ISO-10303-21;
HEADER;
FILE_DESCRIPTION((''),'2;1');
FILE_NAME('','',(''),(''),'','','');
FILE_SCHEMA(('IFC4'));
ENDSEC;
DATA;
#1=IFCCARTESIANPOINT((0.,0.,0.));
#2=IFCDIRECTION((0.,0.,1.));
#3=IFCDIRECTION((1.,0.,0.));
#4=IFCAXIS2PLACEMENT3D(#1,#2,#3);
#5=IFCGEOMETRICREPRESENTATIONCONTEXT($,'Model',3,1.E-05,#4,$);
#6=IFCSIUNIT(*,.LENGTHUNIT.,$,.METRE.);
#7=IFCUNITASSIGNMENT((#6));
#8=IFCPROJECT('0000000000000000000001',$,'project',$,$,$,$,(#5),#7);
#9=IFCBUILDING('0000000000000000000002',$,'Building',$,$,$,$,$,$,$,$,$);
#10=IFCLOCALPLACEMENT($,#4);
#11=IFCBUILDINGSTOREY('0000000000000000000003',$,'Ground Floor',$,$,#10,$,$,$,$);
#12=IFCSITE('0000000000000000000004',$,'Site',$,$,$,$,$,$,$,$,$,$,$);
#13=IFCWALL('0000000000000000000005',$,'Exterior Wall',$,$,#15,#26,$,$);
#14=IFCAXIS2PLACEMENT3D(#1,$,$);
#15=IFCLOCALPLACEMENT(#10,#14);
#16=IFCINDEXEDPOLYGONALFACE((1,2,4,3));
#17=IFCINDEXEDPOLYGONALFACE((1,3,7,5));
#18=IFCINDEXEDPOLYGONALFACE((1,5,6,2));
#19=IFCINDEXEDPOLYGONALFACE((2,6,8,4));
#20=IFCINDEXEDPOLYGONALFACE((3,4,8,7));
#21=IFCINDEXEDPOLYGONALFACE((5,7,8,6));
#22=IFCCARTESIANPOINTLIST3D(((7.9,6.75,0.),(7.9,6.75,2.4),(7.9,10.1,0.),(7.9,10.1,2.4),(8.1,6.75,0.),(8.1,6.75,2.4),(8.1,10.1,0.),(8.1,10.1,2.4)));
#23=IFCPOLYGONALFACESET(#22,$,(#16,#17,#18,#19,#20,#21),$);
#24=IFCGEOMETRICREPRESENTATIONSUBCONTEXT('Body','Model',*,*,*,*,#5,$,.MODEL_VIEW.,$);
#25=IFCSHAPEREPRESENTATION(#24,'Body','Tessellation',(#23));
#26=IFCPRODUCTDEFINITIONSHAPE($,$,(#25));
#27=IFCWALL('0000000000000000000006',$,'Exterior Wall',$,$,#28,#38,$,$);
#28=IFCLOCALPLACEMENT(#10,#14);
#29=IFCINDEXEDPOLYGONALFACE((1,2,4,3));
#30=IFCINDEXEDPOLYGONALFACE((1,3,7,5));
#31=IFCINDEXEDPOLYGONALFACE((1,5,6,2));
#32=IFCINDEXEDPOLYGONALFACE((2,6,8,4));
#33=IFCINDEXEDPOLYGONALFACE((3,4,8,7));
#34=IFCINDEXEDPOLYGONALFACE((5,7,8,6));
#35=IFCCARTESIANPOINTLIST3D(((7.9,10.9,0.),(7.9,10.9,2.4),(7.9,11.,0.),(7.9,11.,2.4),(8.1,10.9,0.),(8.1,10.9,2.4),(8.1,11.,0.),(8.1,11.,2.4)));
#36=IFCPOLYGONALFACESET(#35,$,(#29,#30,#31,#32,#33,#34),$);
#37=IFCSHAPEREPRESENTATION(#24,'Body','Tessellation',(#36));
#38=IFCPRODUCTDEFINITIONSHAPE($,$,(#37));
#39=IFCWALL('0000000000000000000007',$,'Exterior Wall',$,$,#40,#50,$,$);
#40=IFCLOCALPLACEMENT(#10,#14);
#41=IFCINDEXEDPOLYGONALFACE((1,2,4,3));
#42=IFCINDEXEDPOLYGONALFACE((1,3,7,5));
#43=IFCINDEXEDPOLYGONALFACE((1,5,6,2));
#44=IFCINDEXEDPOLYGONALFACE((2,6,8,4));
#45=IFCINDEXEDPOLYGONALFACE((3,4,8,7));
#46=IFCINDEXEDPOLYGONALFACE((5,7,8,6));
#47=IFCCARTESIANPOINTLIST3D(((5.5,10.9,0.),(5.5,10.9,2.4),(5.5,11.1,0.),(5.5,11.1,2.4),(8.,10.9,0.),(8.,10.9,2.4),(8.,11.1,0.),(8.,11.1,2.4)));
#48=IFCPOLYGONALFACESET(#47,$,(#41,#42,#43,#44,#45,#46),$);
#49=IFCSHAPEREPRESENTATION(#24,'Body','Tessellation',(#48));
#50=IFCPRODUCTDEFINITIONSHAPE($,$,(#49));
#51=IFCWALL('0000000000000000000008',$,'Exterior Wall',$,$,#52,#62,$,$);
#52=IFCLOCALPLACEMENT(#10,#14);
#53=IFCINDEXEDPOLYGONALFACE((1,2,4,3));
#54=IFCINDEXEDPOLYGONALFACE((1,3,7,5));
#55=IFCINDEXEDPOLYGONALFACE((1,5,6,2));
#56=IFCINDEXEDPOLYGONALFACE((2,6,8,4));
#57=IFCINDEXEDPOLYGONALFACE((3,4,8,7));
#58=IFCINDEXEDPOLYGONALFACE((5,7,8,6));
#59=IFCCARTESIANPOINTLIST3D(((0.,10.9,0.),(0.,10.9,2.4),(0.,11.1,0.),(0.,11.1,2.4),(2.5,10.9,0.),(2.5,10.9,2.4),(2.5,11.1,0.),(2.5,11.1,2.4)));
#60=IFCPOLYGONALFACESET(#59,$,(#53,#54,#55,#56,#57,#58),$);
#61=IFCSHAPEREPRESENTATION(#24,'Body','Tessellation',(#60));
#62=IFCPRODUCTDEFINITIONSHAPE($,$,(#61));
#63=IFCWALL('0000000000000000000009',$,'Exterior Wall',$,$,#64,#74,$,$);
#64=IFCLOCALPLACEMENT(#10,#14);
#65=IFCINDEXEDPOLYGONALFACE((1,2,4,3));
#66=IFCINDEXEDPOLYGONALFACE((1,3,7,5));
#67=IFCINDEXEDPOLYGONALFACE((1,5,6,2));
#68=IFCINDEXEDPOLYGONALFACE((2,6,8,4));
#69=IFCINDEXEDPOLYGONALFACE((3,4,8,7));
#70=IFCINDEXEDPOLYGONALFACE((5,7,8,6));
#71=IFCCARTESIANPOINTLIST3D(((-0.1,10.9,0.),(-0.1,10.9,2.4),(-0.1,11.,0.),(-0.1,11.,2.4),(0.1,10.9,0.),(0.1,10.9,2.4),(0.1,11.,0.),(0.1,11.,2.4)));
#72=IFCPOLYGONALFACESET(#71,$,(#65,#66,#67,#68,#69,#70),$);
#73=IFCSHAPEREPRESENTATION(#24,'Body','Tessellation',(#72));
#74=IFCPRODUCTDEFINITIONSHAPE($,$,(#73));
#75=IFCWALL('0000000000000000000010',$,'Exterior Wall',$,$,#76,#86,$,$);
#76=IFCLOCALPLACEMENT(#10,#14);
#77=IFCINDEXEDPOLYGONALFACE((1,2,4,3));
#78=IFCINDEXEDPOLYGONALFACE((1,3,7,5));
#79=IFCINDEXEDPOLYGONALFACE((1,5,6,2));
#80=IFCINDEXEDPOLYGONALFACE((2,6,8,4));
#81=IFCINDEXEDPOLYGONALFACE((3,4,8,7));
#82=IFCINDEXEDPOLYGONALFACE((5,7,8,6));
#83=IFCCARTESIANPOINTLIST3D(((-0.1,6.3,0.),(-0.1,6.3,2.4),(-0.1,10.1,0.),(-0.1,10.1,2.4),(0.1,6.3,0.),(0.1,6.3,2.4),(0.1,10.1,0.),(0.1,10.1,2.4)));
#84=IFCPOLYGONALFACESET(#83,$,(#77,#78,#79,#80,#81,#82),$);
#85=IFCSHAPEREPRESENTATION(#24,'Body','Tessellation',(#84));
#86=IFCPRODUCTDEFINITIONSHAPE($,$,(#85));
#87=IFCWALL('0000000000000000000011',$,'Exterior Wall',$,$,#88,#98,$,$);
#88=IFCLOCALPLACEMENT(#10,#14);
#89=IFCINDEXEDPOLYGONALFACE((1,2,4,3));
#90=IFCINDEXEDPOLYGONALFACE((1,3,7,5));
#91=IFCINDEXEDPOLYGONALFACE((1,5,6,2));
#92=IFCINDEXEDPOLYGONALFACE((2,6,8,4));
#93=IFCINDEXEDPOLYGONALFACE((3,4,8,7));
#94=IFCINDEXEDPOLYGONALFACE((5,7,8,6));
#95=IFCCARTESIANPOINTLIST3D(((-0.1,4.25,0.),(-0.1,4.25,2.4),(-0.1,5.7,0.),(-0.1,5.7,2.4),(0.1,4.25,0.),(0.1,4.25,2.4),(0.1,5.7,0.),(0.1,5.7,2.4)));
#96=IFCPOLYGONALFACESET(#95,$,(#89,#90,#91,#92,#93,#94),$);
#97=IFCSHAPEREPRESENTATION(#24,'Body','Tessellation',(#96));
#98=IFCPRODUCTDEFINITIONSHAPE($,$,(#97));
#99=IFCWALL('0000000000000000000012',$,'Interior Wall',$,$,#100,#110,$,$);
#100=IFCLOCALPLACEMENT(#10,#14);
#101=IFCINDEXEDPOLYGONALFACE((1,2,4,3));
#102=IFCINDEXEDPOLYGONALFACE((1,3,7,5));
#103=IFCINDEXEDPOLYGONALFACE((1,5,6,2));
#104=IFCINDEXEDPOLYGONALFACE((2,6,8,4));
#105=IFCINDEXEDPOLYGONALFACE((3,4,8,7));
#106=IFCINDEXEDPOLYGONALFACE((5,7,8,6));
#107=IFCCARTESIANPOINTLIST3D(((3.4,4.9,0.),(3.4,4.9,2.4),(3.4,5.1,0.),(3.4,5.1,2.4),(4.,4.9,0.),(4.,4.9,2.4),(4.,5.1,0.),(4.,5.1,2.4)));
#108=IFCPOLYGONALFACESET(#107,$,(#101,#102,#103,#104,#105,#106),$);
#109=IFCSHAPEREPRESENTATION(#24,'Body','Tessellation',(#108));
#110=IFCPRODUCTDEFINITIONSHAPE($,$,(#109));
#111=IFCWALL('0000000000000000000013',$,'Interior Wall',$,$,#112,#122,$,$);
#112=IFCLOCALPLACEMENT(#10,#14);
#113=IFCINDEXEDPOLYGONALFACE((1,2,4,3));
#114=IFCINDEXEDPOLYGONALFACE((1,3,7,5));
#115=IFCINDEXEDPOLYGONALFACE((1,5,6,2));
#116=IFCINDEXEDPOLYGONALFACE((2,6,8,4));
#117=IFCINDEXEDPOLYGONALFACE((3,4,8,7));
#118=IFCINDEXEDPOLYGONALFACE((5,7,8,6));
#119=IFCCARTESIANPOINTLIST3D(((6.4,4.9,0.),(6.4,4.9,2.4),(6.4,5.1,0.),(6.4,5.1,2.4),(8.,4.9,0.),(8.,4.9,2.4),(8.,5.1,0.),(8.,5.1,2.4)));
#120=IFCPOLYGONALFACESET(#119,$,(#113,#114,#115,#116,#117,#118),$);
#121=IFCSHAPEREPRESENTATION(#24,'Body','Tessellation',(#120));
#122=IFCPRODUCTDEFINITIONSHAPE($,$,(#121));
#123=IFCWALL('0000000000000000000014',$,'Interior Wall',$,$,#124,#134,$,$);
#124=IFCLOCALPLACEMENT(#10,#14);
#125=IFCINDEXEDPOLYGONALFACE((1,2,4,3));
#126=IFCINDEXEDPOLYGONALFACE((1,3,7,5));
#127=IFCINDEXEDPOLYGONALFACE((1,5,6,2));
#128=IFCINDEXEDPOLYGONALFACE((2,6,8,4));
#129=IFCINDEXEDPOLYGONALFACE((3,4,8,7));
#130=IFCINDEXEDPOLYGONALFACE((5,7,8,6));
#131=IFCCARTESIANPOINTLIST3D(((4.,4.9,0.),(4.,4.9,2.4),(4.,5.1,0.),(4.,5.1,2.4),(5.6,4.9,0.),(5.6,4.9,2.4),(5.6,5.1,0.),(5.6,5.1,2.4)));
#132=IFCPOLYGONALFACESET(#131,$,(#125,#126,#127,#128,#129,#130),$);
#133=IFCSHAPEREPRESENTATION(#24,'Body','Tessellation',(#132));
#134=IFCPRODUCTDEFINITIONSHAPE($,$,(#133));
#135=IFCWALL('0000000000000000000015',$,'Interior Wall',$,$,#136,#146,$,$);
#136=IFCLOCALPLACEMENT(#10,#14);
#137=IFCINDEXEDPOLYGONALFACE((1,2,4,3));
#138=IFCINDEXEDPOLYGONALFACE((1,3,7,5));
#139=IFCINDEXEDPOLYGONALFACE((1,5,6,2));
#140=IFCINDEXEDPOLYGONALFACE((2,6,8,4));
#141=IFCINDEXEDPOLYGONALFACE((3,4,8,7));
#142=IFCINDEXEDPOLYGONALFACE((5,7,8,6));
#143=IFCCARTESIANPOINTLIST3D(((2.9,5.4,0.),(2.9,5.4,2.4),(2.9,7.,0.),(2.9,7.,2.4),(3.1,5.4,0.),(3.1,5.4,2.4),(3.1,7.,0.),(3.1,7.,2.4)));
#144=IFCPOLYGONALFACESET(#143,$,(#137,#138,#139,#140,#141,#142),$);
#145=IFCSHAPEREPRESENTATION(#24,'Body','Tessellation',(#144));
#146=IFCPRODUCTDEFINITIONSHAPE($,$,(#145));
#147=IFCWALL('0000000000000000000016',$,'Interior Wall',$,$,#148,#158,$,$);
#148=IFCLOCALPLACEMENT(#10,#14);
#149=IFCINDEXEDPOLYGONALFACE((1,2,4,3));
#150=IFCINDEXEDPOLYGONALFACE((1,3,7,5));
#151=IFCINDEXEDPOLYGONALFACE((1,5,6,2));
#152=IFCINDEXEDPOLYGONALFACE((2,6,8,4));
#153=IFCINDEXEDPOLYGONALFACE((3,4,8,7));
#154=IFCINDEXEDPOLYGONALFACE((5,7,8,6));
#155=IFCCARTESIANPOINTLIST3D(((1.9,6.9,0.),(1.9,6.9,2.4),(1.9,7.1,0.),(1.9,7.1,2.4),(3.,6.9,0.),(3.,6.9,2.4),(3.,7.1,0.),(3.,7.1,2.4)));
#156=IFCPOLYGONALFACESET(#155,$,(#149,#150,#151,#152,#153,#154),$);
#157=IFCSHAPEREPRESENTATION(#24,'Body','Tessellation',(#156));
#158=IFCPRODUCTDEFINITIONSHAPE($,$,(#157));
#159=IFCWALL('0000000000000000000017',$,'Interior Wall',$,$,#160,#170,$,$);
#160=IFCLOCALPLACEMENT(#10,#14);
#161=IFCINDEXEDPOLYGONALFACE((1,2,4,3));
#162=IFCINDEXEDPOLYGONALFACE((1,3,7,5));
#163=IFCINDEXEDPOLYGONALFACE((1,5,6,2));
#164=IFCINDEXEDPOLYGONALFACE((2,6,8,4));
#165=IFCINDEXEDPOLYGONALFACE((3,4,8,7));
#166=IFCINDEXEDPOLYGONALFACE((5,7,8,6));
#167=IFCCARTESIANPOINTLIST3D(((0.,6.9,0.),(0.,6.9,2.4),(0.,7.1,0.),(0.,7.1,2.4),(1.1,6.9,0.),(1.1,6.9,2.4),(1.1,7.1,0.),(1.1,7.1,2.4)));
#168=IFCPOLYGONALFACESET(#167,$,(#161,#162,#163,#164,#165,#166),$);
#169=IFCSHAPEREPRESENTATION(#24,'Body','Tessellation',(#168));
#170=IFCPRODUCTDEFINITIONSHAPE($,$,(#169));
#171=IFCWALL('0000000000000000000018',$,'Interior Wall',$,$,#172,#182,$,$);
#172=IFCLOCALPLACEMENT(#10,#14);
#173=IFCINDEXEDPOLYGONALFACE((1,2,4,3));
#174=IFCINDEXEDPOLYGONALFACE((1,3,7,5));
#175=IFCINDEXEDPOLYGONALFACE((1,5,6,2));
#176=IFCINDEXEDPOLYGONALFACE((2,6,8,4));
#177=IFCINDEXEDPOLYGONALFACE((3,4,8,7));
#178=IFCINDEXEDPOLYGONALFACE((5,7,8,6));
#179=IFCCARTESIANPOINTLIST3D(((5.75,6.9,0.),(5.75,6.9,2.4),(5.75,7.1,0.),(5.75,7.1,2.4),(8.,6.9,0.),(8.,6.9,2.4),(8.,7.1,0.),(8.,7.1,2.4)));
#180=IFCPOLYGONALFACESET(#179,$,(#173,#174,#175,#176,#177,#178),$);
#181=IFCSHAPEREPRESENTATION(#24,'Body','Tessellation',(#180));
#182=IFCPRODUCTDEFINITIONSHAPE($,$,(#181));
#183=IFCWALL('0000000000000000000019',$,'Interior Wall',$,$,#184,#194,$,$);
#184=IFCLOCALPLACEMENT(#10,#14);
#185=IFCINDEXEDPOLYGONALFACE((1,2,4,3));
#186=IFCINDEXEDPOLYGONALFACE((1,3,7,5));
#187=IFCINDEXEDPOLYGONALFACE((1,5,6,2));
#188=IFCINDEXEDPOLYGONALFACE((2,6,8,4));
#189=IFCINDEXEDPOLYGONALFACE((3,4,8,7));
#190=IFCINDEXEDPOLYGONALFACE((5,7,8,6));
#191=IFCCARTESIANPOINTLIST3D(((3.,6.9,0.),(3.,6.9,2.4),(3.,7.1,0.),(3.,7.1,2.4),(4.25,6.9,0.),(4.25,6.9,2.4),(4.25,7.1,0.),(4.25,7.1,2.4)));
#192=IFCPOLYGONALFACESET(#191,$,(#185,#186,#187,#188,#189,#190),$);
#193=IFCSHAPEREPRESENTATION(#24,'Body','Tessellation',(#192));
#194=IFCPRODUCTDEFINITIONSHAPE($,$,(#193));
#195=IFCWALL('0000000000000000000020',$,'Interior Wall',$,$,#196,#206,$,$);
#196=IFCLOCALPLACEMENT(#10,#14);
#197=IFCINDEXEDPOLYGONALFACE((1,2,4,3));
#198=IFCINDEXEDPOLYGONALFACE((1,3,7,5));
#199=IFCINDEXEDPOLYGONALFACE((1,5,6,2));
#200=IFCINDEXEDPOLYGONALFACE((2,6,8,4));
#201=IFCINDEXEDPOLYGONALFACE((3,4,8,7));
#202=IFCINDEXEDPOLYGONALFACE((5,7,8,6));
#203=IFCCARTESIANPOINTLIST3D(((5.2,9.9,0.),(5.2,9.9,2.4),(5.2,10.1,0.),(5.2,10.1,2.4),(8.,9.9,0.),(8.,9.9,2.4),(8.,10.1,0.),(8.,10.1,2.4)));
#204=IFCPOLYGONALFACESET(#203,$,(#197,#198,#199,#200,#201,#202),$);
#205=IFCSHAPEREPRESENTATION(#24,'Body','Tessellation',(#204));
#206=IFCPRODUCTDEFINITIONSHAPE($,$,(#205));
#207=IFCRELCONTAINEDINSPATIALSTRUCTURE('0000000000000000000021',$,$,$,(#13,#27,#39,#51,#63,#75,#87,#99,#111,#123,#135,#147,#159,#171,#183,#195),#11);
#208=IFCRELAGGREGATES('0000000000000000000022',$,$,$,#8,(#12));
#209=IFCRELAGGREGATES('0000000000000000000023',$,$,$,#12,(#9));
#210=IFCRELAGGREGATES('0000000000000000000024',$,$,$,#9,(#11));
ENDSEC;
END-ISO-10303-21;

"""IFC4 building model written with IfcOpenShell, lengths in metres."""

from ifc_helpers import new_model, si_unit, frame, origin_with_axes, place, context, subcontext, project, spatial, indexed_curve, outline, extrude, element, save


model = new_model("IFC4")

# Units and contexts
model_context = context("Model", 3, precision=1e-05, world=origin_with_axes())
body_context = subcontext(model_context, "Body", "Model", "MODEL_VIEW")
ifc_project = project(units=[si_unit("LENGTHUNIT", "METRE")], contexts=[model_context])

# Site, building, storey
site = spatial("IfcSite", under=ifc_project, Name="Site")
building = spatial("IfcBuilding", under=site, Name="Building")
storey_placement = place(None, origin_with_axes())
storey = spatial("IfcBuildingStorey", under=building, at=storey_placement, Name="Ground Floor")

# Walls
wall_1_placement = place(storey_placement, frame((8.0, 6.75, 0.0), z_axis=(0.0, 0.0, 1.0), x_axis=(0.0, 1.0, 0.0)))
element("IfcWall", 1, at=wall_1_placement, inside=storey, Name="Exterior Wall", context=body_context, shape_type="SweptSolid", body=[
    extrude(outline(indexed_curve([(0.0, 0.0), (0.0, 0.2), (3.35, 0.2), (3.35, 0.0), (0.0, 0.0)], self_intersect=False)), frame((0.0, -0.1, 0.0), z_axis=(0.0, 0.0, 1.0), x_axis=(1.0, 0.0, 0.0)), (0.0, 0.0, 1.0), 2.4),
])
wall_2_placement = place(storey_placement, frame((8.0, 10.9, 0.0), z_axis=(0.0, 0.0, 1.0), x_axis=(0.0, 1.0, 0.0)))
element("IfcWall", 2, at=wall_2_placement, inside=storey, Name="Exterior Wall", context=body_context, shape_type="SweptSolid", body=[
    extrude(outline(indexed_curve([(0.0, 0.0), (0.0, 0.2), (0.1, 0.2), (0.1, 0.0), (0.0, 0.0)], self_intersect=False)), frame((0.0, -0.1, 0.0), z_axis=(0.0, 0.0, 1.0), x_axis=(1.0, 0.0, 0.0)), (0.0, 0.0, 1.0), 2.4),
])
for number, where, z_axis, x_axis, name in (
    (3, (8.0, 11.0, 0.0), (0.0, 0.0, 1.0), (-1.0, 0.0, 0.0), "Exterior Wall"),
    (4, (2.5, 11.0, 0.0), (0.0, 0.0, 1.0), (-1.0, 0.0, 0.0), "Exterior Wall"),
):
    element("IfcWall", number, at=place(storey_placement, frame(where, z_axis=z_axis, x_axis=x_axis)), inside=storey, Name=name, context=body_context, shape_type="SweptSolid", body=[
        extrude(outline(indexed_curve([(0.0, 0.0), (0.0, 0.2), (2.5, 0.2), (2.5, 0.0), (0.0, 0.0)], self_intersect=False)), frame((0.0, -0.1, 0.0), z_axis=(0.0, 0.0, 1.0), x_axis=(1.0, 0.0, 0.0)), (0.0, 0.0, 1.0), 2.4),
    ])
wall_3_placement = place(storey_placement, frame((0.0, 11.0, 0.0), z_axis=(0.0, 0.0, 1.0), x_axis=(0.0, -1.0, 0.0)))
element("IfcWall", 5, at=wall_3_placement, inside=storey, Name="Exterior Wall", context=body_context, shape_type="SweptSolid", body=[
    extrude(outline(indexed_curve([(0.0, 0.0), (0.0, 0.2), (0.1, 0.2), (0.1, 0.0), (0.0, 0.0)], self_intersect=False)), frame((0.0, -0.1, 0.0), z_axis=(0.0, 0.0, 1.0), x_axis=(1.0, 0.0, 0.0)), (0.0, 0.0, 1.0), 2.4),
])
wall_4_placement = place(storey_placement, frame((0.0, 10.1, 0.0), z_axis=(0.0, 0.0, 1.0), x_axis=(0.0, -1.0, 0.0)))
element("IfcWall", 6, at=wall_4_placement, inside=storey, Name="Exterior Wall", context=body_context, shape_type="SweptSolid", body=[
    extrude(outline(indexed_curve([(0.0, 0.0), (0.0, 0.2), (3.8, 0.2), (3.8, 0.0), (0.0, 0.0)], self_intersect=False)), frame((0.0, -0.1, 0.0), z_axis=(0.0, 0.0, 1.0), x_axis=(1.0, 0.0, 0.0)), (0.0, 0.0, 1.0), 2.4),
])
wall_5_placement = place(storey_placement, frame((0.0, 5.7, 0.0), z_axis=(0.0, 0.0, 1.0), x_axis=(0.0, -1.0, 0.0)))
element("IfcWall", 7, at=wall_5_placement, inside=storey, Name="Exterior Wall", context=body_context, shape_type="SweptSolid", body=[
    extrude(outline(indexed_curve([(0.0, 0.0), (0.0, 0.2), (1.45, 0.2), (1.45, 0.0), (0.0, 0.0)], self_intersect=False)), frame((0.0, -0.1, 0.0), z_axis=(0.0, 0.0, 1.0), x_axis=(1.0, 0.0, 0.0)), (0.0, 0.0, 1.0), 2.4),
])
wall_6_placement = place(storey_placement, frame((4.0, 5.0, 0.0), z_axis=(0.0, 0.0, 1.0), x_axis=(-1.0, 0.0, 0.0)))
element("IfcWall", 8, at=wall_6_placement, inside=storey, Name="Interior Wall", context=body_context, shape_type="SweptSolid", body=[
    extrude(outline(indexed_curve([(0.0, 0.0), (0.0, 0.2), (0.6, 0.2), (0.6, 0.0), (0.0, 0.0)], self_intersect=False)), frame((0.0, -0.1, 0.0), z_axis=(0.0, 0.0, 1.0), x_axis=(1.0, 0.0, 0.0)), (0.0, 0.0, 1.0), 2.4),
])
for number, where, z_axis, x_axis, name in (
    (9, (8.0, 5.0, 0.0), (0.0, 0.0, 1.0), (-1.0, 0.0, 0.0), "Interior Wall"),
    (10, (5.6, 5.0, 0.0), (0.0, 0.0, 1.0), (-1.0, 0.0, 0.0), "Interior Wall"),
    (11, (3.0, 5.4, 0.0), (0.0, 0.0, 1.0), (0.0, 1.0, 0.0), "Interior Wall"),
):
    element("IfcWall", number, at=place(storey_placement, frame(where, z_axis=z_axis, x_axis=x_axis)), inside=storey, Name=name, context=body_context, shape_type="SweptSolid", body=[
        extrude(outline(indexed_curve([(0.0, 0.0), (0.0, 0.2), (1.6, 0.2), (1.6, 0.0), (0.0, 0.0)], self_intersect=False)), frame((0.0, -0.1, 0.0), z_axis=(0.0, 0.0, 1.0), x_axis=(1.0, 0.0, 0.0)), (0.0, 0.0, 1.0), 2.4),
    ])
for number, where, z_axis, x_axis, name in (
    (12, (3.0, 7.0, 0.0), (0.0, 0.0, 1.0), (-1.0, 0.0, 0.0), "Interior Wall"),
    (13, (1.1, 7.0, 0.0), (0.0, 0.0, 1.0), (-1.0, 0.0, 0.0), "Interior Wall"),
):
    element("IfcWall", number, at=place(storey_placement, frame(where, z_axis=z_axis, x_axis=x_axis)), inside=storey, Name=name, context=body_context, shape_type="SweptSolid", body=[
        extrude(outline(indexed_curve([(0.0, 0.0), (0.0, 0.2), (1.1, 0.2), (1.1, 0.0), (0.0, 0.0)], self_intersect=False)), frame((0.0, -0.1, 0.0), z_axis=(0.0, 0.0, 1.0), x_axis=(1.0, 0.0, 0.0)), (0.0, 0.0, 1.0), 2.4),
    ])
wall_7_placement = place(storey_placement, frame((8.0, 7.0, 0.0), z_axis=(0.0, 0.0, 1.0), x_axis=(-1.0, 0.0, 0.0)))
element("IfcWall", 14, at=wall_7_placement, inside=storey, Name="Interior Wall", context=body_context, shape_type="SweptSolid", body=[
    extrude(outline(indexed_curve([(0.0, 0.0), (0.0, 0.2), (2.25, 0.2), (2.25, 0.0), (0.0, 0.0)], self_intersect=False)), frame((0.0, -0.1, 0.0), z_axis=(0.0, 0.0, 1.0), x_axis=(1.0, 0.0, 0.0)), (0.0, 0.0, 1.0), 2.4),
])
wall_8_placement = place(storey_placement, frame((4.25, 7.0, 0.0), z_axis=(0.0, 0.0, 1.0), x_axis=(-1.0, 0.0, 0.0)))
element("IfcWall", 15, at=wall_8_placement, inside=storey, Name="Interior Wall", context=body_context, shape_type="SweptSolid", body=[
    extrude(outline(indexed_curve([(0.0, 0.0), (0.0, 0.2), (1.25, 0.2), (1.25, 0.0), (0.0, 0.0)], self_intersect=False)), frame((0.0, -0.1, 0.0), z_axis=(0.0, 0.0, 1.0), x_axis=(1.0, 0.0, 0.0)), (0.0, 0.0, 1.0), 2.4),
])
for number, where, z_axis, x_axis, name in (
    (16, (8.0, 10.0, 0.0), (0.0, 0.0, 1.0), (-1.0, 0.0, 0.0), "Interior Wall"),
):
    element("IfcWall", number, at=place(storey_placement, frame(where, z_axis=z_axis, x_axis=x_axis)), inside=storey, Name=name, context=body_context, shape_type="SweptSolid", body=[
        extrude(outline(indexed_curve([(0.0, 0.0), (0.0, 0.2), (2.8, 0.2), (2.8, 0.0), (0.0, 0.0)], self_intersect=False)), frame((0.0, -0.1, 0.0), z_axis=(0.0, 0.0, 1.0), x_axis=(1.0, 0.0, 0.0)), (0.0, 0.0, 1.0), 2.4),
    ])

save(model, "model.ifc")
